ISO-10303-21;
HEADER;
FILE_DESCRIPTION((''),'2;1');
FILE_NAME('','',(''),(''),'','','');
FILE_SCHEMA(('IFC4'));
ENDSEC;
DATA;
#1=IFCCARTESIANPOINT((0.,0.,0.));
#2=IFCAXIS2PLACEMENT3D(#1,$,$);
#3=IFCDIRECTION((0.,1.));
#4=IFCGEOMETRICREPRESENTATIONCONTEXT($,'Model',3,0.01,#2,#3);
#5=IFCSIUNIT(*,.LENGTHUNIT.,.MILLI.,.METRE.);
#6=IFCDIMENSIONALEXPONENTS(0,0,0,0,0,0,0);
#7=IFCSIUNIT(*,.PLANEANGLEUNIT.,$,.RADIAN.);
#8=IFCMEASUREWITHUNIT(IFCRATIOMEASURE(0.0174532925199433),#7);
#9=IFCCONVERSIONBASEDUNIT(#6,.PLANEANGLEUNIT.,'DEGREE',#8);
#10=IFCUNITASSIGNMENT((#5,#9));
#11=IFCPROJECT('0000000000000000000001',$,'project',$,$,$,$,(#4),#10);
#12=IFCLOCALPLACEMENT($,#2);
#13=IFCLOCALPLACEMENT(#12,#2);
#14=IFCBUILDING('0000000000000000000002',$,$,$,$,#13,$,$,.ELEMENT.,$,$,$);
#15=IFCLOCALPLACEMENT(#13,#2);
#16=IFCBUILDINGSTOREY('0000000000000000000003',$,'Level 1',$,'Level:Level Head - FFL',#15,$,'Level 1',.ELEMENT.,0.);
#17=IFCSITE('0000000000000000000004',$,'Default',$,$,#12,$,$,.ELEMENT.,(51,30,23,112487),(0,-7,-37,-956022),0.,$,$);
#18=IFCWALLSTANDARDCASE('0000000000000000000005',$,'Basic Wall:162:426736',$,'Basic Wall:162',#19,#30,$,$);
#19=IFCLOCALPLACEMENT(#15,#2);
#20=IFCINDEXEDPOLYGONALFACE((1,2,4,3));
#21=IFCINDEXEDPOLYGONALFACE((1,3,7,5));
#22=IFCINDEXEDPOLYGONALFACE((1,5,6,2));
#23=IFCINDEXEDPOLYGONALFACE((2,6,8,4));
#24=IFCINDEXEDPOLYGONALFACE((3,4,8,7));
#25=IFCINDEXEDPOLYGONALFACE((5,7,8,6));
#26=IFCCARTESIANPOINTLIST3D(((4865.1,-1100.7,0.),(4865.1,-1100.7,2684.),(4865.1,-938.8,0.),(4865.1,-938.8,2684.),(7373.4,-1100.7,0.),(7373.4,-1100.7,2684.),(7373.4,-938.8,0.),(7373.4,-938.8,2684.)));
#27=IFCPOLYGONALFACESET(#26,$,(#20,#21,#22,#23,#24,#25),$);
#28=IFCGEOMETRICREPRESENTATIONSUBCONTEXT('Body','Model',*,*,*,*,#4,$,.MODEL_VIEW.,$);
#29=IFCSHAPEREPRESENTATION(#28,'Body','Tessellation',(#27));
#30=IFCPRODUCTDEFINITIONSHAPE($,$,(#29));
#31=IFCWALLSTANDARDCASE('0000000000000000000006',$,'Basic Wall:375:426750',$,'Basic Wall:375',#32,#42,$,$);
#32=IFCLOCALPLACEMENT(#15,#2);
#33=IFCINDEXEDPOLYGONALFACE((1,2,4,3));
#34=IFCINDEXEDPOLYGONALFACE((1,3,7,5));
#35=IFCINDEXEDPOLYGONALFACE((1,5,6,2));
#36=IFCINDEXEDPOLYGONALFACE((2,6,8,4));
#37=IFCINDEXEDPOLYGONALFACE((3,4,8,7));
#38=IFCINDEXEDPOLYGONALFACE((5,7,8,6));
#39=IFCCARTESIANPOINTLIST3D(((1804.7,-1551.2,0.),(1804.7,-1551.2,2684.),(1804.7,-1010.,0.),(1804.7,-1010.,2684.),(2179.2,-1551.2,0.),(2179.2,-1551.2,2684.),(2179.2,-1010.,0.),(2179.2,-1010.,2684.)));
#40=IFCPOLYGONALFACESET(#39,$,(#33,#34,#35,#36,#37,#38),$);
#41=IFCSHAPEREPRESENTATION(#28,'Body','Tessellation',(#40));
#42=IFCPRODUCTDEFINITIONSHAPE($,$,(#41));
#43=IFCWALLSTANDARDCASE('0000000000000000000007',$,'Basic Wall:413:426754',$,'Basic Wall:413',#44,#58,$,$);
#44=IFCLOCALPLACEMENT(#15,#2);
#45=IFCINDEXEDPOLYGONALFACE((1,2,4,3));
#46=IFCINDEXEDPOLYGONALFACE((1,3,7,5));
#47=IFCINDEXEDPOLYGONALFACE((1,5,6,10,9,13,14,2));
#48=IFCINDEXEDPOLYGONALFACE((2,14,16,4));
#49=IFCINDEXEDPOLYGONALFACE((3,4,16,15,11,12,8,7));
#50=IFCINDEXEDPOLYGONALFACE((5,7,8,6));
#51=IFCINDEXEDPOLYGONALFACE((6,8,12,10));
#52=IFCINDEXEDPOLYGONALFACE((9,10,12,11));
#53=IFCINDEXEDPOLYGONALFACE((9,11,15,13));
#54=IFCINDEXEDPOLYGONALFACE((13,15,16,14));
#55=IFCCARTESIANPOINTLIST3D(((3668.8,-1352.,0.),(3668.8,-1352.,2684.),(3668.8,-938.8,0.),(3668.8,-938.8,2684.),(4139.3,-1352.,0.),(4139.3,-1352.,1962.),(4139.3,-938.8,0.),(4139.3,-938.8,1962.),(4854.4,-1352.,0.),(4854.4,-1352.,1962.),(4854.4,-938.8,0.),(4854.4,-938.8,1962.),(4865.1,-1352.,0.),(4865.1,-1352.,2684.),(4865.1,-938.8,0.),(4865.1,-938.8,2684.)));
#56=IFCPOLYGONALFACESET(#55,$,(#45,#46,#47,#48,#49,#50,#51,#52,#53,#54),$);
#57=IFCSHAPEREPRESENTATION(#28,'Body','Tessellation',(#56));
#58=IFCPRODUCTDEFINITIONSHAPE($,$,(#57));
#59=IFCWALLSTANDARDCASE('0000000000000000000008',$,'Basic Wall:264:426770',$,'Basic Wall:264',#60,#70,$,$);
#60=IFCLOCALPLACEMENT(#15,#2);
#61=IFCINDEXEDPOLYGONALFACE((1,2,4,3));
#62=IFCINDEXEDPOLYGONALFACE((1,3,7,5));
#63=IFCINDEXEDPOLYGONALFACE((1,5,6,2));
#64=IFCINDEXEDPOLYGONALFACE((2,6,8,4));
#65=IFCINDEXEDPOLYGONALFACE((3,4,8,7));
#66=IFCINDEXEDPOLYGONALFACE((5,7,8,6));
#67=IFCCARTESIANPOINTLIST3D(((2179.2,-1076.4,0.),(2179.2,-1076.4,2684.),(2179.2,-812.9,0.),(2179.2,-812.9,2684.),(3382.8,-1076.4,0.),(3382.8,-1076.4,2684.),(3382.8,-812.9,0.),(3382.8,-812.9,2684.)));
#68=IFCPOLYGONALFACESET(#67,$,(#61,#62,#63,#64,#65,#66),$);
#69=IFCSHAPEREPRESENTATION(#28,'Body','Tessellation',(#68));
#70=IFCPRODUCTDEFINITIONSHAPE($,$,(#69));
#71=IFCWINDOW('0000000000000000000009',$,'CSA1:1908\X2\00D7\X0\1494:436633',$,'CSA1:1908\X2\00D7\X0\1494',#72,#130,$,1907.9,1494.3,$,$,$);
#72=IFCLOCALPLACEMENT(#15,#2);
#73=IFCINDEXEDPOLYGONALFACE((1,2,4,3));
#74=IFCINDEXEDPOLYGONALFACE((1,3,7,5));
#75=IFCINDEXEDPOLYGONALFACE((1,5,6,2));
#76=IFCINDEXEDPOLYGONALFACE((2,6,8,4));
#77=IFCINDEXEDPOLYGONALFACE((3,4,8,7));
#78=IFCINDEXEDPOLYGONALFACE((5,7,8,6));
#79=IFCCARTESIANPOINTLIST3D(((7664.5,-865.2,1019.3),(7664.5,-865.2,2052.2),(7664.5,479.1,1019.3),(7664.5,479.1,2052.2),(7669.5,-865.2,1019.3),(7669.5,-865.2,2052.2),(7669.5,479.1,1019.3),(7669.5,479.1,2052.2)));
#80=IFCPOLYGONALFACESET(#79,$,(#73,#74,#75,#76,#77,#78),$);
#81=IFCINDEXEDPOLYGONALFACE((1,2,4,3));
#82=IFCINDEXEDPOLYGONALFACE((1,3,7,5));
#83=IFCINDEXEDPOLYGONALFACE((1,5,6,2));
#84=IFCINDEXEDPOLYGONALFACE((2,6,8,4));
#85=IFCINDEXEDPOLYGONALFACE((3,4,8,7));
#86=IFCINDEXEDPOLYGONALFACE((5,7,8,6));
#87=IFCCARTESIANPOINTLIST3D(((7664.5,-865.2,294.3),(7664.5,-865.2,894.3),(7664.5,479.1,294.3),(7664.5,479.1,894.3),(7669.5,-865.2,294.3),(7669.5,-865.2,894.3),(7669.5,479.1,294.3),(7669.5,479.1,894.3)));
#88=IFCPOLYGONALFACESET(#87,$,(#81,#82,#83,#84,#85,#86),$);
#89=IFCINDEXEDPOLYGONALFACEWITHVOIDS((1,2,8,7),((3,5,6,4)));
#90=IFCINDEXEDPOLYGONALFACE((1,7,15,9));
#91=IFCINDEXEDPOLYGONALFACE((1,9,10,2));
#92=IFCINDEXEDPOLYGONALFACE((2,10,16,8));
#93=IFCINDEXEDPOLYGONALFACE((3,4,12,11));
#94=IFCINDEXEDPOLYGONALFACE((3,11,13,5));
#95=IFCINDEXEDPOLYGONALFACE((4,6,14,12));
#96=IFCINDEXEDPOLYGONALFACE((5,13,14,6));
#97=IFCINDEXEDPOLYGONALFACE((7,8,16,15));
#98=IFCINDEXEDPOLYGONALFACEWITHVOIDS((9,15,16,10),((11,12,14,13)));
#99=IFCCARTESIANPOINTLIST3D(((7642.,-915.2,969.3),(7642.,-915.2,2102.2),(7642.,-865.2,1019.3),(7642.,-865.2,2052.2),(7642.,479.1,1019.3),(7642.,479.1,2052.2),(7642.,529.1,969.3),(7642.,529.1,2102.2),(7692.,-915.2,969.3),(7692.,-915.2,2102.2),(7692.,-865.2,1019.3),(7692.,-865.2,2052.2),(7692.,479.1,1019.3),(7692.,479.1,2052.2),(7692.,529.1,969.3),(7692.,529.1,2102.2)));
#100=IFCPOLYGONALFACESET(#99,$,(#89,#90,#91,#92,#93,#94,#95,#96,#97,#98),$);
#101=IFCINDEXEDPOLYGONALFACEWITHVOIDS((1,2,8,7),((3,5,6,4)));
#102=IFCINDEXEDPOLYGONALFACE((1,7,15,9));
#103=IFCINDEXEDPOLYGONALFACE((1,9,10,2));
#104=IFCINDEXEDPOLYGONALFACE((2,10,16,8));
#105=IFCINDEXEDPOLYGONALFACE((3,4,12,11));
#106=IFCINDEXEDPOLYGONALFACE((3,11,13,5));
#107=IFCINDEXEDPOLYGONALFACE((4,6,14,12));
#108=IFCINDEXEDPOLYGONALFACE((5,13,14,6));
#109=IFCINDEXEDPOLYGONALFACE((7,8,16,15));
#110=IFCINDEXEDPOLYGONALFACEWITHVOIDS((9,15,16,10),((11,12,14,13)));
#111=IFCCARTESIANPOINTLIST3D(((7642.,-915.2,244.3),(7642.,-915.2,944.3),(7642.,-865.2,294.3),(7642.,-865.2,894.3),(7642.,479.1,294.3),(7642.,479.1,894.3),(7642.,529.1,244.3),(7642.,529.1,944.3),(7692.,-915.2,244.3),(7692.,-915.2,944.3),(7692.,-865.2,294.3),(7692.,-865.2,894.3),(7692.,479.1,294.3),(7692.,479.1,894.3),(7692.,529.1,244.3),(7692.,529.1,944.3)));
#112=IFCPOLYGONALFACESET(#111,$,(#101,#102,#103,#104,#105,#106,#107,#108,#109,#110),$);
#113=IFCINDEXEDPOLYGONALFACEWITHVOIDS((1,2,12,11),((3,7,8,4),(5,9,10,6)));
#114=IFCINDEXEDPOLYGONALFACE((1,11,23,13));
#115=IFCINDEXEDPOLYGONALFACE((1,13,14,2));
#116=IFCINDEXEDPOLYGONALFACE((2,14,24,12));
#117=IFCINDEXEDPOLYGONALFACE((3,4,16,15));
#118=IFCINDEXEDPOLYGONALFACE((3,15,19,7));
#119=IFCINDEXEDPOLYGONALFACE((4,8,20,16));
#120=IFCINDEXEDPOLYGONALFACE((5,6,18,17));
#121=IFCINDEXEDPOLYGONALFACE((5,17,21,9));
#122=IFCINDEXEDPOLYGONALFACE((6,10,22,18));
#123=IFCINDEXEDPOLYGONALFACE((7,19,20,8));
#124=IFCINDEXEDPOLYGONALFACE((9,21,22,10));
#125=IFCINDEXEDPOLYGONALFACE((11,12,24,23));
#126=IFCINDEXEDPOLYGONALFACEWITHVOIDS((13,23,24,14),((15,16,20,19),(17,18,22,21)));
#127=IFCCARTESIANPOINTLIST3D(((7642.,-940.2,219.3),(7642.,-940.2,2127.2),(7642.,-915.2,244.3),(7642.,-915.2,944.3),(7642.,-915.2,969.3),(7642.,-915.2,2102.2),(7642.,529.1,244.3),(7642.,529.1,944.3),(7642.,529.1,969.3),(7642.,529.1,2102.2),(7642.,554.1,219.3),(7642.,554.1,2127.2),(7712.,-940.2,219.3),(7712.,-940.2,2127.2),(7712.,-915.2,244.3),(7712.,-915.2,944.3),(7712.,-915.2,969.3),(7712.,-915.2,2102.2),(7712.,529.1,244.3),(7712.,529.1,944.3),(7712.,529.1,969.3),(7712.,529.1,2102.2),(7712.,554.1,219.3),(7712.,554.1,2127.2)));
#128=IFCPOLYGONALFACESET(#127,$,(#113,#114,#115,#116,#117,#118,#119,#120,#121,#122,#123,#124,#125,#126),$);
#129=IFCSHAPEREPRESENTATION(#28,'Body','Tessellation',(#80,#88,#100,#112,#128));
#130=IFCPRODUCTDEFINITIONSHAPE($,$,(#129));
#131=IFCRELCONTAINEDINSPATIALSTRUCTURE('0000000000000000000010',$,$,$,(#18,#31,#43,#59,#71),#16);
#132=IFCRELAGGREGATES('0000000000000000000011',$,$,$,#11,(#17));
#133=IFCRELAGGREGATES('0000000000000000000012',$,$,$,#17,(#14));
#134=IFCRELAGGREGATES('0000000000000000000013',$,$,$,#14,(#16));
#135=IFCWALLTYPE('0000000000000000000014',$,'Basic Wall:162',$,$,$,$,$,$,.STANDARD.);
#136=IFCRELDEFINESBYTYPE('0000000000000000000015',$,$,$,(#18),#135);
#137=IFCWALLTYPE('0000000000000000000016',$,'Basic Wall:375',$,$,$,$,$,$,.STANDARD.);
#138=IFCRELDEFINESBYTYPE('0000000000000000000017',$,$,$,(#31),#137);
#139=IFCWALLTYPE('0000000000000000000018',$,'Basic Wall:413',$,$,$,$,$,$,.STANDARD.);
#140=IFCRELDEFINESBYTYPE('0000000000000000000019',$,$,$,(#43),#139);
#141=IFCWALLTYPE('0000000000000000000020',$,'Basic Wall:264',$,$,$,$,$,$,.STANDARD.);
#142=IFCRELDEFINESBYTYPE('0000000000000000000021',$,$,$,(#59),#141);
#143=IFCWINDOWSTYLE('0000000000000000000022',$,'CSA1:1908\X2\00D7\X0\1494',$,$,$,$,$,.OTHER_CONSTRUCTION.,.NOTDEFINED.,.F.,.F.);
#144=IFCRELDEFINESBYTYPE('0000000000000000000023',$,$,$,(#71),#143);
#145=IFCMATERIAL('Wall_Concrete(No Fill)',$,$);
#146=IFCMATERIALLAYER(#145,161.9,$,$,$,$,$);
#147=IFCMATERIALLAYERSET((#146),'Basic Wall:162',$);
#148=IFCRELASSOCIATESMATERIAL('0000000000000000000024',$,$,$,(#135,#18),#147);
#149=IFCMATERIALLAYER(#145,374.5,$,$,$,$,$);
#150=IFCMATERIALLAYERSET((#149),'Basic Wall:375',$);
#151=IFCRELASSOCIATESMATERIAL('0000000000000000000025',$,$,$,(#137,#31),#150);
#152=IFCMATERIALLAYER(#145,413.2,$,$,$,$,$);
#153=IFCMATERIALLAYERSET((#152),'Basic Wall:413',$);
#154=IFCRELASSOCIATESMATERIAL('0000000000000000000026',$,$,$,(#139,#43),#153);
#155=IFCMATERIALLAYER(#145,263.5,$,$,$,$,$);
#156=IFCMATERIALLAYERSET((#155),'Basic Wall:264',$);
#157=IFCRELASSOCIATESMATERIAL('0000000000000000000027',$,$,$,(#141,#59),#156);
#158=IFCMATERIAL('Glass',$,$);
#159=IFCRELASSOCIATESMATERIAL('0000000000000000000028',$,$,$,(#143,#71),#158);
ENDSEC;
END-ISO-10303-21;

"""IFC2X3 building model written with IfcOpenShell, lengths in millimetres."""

from ifc_helpers import new_model, entity, si_unit, converted_unit, direction, frame, frame_2d, origin, place, context, subcontext, project, spatial, polyline, rectangle, outline, extrude, source, transform, mapped, material, layer, layer_set, layer_usage, type_object, type_shapes, element, save


model = new_model("IFC2X3")

# Units and contexts
model_context = context("Model", 3, precision=0.01, world=origin(), true_north=direction((0.0, 1.0)))
body_context = subcontext(model_context, "Body", "Model", "MODEL_VIEW")
ifc_project = project(units=[si_unit("LENGTHUNIT", "METRE", prefix="MILLI"), converted_unit("PLANEANGLEUNIT", "DEGREE", entity("IfcRatioMeasure", 0.0174532925199433), si_unit("PLANEANGLEUNIT", "RADIAN"), dimensions=[0, 0, 0, 0, 0, 0, 0])], contexts=[model_context])

# Site, building, storey
site_placement = place(None, origin())
site = spatial("IfcSite", under=ifc_project, at=site_placement, Name="Default", CompositionType="ELEMENT", RefLatitude=(51, 30, 23, 112487), RefLongitude=(0, -7, -37, -956022), RefElevation=0.0)
building_placement = place(site_placement, origin())
building = spatial("IfcBuilding", under=site, at=building_placement, CompositionType="ELEMENT")
storey_placement = place(building_placement, origin())
storey = spatial("IfcBuildingStorey", under=building, at=storey_placement, Name="Level 1", ObjectType="Level:Level Head - FFL", LongName="Level 1", CompositionType="ELEMENT", Elevation=0.0)

# Shared definitions
ifc_material_1 = material(Name="Wall_Concrete(No Fill)")

# Walls
ifc_layer_1 = layer(ifc_material_1, 161.9)
ifc_layer_set_1 = layer_set([ifc_layer_1], Name="Basic Wall:162")
ifc_layer_usage_1 = layer_usage(ifc_layer_set_1, "AXIS2", "NEGATIVE", 80.9)
wall_type_1 = type_object("IfcWallType", Name="Basic Wall:162", PredefinedType="STANDARD", material=ifc_layer_set_1)
wall_1_placement = place(storey_placement, frame((4865.1, -1019.8, 0.0)))
element("IfcWallStandardCase", 1, at=wall_1_placement, inside=storey, type_object=wall_type_1, material=ifc_layer_usage_1, Name="Basic Wall:162:426736", ObjectType="Basic Wall:162", context=body_context, shape_type="SweptSolid", body=[
    extrude(rectangle(XDim=2508.4, YDim=161.9, at=frame_2d((1254.2, 0.0), x_axis=(-1.0, 0.0))), origin(), (0.0, 0.0, 1.0), 2684.0),
])
ifc_layer_2 = layer(ifc_material_1, 374.5)
ifc_layer_set_2 = layer_set([ifc_layer_2], Name="Basic Wall:375")
ifc_layer_usage_2 = layer_usage(ifc_layer_set_2, "AXIS2", "NEGATIVE", 187.3)
wall_type_2 = type_object("IfcWallType", Name="Basic Wall:375", PredefinedType="STANDARD", material=ifc_layer_set_2)
wall_2_placement = place(storey_placement, frame((1992.0, -1551.2, 0.0), z_axis=(0.0, 0.0, 1.0), x_axis=(0.0, 1.0, 0.0)))
element("IfcWallStandardCase", 2, at=wall_2_placement, inside=storey, type_object=wall_type_2, material=ifc_layer_usage_2, Name="Basic Wall:375:426750", ObjectType="Basic Wall:375", context=body_context, shape_type="SweptSolid", body=[
    extrude(rectangle(XDim=541.2, YDim=374.5, at=frame_2d((270.6, 0.0), x_axis=(-1.0, 0.0))), origin(), (0.0, 0.0, 1.0), 2684.0),
])

# Wall, opening
ifc_layer_3 = layer(ifc_material_1, 413.2)
ifc_layer_set_3 = layer_set([ifc_layer_3], Name="Basic Wall:413")
ifc_layer_usage_3 = layer_usage(ifc_layer_set_3, "AXIS2", "NEGATIVE", 206.6)
wall_type_3 = type_object("IfcWallType", Name="Basic Wall:413", PredefinedType="STANDARD", material=ifc_layer_set_3)
wall_3_placement = place(storey_placement, frame((3668.8, -1145.4, 0.0)))
wall_3 = element("IfcWallStandardCase", 3, at=wall_3_placement, inside=storey, type_object=wall_type_3, material=ifc_layer_usage_3, Name="Basic Wall:413:426754", ObjectType="Basic Wall:413", context=body_context, shape_type="SweptSolid", body=[
    extrude(rectangle(XDim=1196.3, YDim=413.2, at=frame_2d((598.1, 0.0), x_axis=(-1.0, 0.0))), origin(), (0.0, 0.0, 1.0), 2684.0),
])
opening_1_placement = place(wall_3_placement, origin())
element("IfcOpeningElement", 4, at=opening_1_placement, cuts=wall_3, ObjectType="Opening", context=body_context, shape_type="SweptSolid", body=[
    extrude(rectangle(XDim=1962.0, YDim=715.1, at=frame_2d((0.0, 0.0), x_axis=(1.0, 0.0))), frame((828.0, -206.6, 981.0), z_axis=(0.0, 1.0, 0.0), x_axis=(0.0, 0.0, -1.0)), (0.0, 0.0, 1.0), 413.2),
])

# Wall
ifc_layer_4 = layer(ifc_material_1, 263.5)
ifc_layer_set_4 = layer_set([ifc_layer_4], Name="Basic Wall:264")
ifc_layer_usage_4 = layer_usage(ifc_layer_set_4, "AXIS2", "NEGATIVE", 131.8)
wall_type_4 = type_object("IfcWallType", Name="Basic Wall:264", PredefinedType="STANDARD", material=ifc_layer_set_4)
wall_4_placement = place(storey_placement, frame((2179.2, -944.6, 0.0)))
element("IfcWallStandardCase", 5, at=wall_4_placement, inside=storey, type_object=wall_type_4, material=ifc_layer_usage_4, Name="Basic Wall:264:426770", ObjectType="Basic Wall:264", context=body_context, shape_type="SweptSolid", body=[
    extrude(rectangle(XDim=1203.5, YDim=263.5, at=frame_2d((601.8, 0.0), x_axis=(-1.0, 0.0))), origin(), (0.0, 0.0, 1.0), 2684.0),
])

# Window
ifc_material_2 = material(Name="Glass")
window_style_1 = type_object("IfcWindowStyle", Name="CSA1:1908×1494", ConstructionType="OTHER_CONSTRUCTION", OperationType="NOTDEFINED", ParameterTakesPrecedence=False, Sizeable=False, material=ifc_material_2)
shared_shape_1 = source(origin(), body_context, "Body", "SweptSolid", [
    extrude(rectangle(XDim=5.0, YDim=1344.3, at=frame_2d((0.0, 0.0), x_axis=(1.0, 0.0))), frame((747.2, 45.0, 800.0), z_axis=(0.0, 0.0, 1.0), x_axis=(0.0, 1.0, 0.0)), (0.0, 0.0, 1.0), 1032.9),
    extrude(rectangle(XDim=5.0, YDim=1344.3, at=frame_2d((0.0, 0.0), x_axis=(1.0, 0.0))), frame((747.2, 45.0, 75.0), z_axis=(0.0, 0.0, 1.0), x_axis=(0.0, 1.0, 0.0)), (0.0, 0.0, 1.0), 600.0),
    extrude(outline(polyline([(-722.2, -566.4), (722.2, -566.4), (722.2, 566.4), (-722.2, 566.4), (-722.2, -566.4)]), holes=[polyline([(-672.2, -516.4), (-672.2, 516.4), (672.2, 516.4), (672.2, -516.4), (-672.2, -516.4)])]), frame((747.2, 20.0, 1316.4), z_axis=(0.0, 1.0, 0.0), x_axis=(1.0, 0.0, 0.0)), (0.0, 0.0, 1.0), 50.0),
    extrude(outline(polyline([(-722.2, -350.0), (722.2, -350.0), (722.2, 350.0), (-722.2, 350.0), (-722.2, -350.0)]), holes=[polyline([(-672.2, -300.0), (-672.2, 300.0), (672.2, 300.0), (672.2, -300.0), (-672.2, -300.0)])]), frame((747.2, 20.0, 375.0), z_axis=(0.0, 1.0, 0.0), x_axis=(1.0, 0.0, 0.0)), (0.0, 0.0, 1.0), 50.0),
    extrude(outline(polyline([(-747.2, -953.9), (747.2, -953.9), (747.2, 953.9), (-747.2, 953.9), (-747.2, -953.9)]), holes=[polyline([(-722.2, -928.9), (-722.2, 203.9), (722.2, 203.9), (722.2, -928.9), (-722.2, -928.9)]), polyline([(-722.2, 228.9), (-722.2, 928.9), (722.2, 928.9), (722.2, 228.9), (-722.2, 228.9)])]), frame((747.2, 0.0, 953.9), z_axis=(0.0, 1.0, 0.0), x_axis=(1.0, 0.0, 0.0)), (0.0, 0.0, 1.0), 70.0),
])
type_shapes(window_style_1, [shared_shape_1])
window_1_placement = place(storey_placement, frame((7712.0, -940.2, 219.3), z_axis=(0.0, 0.0, 1.0), x_axis=(0.0, 1.0, 0.0)))
element("IfcWindow", 6, at=window_1_placement, inside=storey, type_object=window_style_1, material=ifc_material_2, Name="CSA1:1908×1494:436633", ObjectType="CSA1:1908×1494", OverallHeight=1907.9, OverallWidth=1494.3, context=body_context, shape_type="MappedRepresentation", body=[
    mapped(shared_shape_1, transform((0.0, 0.0, 0.0), scale=1.0)),
])

save(model, "model.ifc")
